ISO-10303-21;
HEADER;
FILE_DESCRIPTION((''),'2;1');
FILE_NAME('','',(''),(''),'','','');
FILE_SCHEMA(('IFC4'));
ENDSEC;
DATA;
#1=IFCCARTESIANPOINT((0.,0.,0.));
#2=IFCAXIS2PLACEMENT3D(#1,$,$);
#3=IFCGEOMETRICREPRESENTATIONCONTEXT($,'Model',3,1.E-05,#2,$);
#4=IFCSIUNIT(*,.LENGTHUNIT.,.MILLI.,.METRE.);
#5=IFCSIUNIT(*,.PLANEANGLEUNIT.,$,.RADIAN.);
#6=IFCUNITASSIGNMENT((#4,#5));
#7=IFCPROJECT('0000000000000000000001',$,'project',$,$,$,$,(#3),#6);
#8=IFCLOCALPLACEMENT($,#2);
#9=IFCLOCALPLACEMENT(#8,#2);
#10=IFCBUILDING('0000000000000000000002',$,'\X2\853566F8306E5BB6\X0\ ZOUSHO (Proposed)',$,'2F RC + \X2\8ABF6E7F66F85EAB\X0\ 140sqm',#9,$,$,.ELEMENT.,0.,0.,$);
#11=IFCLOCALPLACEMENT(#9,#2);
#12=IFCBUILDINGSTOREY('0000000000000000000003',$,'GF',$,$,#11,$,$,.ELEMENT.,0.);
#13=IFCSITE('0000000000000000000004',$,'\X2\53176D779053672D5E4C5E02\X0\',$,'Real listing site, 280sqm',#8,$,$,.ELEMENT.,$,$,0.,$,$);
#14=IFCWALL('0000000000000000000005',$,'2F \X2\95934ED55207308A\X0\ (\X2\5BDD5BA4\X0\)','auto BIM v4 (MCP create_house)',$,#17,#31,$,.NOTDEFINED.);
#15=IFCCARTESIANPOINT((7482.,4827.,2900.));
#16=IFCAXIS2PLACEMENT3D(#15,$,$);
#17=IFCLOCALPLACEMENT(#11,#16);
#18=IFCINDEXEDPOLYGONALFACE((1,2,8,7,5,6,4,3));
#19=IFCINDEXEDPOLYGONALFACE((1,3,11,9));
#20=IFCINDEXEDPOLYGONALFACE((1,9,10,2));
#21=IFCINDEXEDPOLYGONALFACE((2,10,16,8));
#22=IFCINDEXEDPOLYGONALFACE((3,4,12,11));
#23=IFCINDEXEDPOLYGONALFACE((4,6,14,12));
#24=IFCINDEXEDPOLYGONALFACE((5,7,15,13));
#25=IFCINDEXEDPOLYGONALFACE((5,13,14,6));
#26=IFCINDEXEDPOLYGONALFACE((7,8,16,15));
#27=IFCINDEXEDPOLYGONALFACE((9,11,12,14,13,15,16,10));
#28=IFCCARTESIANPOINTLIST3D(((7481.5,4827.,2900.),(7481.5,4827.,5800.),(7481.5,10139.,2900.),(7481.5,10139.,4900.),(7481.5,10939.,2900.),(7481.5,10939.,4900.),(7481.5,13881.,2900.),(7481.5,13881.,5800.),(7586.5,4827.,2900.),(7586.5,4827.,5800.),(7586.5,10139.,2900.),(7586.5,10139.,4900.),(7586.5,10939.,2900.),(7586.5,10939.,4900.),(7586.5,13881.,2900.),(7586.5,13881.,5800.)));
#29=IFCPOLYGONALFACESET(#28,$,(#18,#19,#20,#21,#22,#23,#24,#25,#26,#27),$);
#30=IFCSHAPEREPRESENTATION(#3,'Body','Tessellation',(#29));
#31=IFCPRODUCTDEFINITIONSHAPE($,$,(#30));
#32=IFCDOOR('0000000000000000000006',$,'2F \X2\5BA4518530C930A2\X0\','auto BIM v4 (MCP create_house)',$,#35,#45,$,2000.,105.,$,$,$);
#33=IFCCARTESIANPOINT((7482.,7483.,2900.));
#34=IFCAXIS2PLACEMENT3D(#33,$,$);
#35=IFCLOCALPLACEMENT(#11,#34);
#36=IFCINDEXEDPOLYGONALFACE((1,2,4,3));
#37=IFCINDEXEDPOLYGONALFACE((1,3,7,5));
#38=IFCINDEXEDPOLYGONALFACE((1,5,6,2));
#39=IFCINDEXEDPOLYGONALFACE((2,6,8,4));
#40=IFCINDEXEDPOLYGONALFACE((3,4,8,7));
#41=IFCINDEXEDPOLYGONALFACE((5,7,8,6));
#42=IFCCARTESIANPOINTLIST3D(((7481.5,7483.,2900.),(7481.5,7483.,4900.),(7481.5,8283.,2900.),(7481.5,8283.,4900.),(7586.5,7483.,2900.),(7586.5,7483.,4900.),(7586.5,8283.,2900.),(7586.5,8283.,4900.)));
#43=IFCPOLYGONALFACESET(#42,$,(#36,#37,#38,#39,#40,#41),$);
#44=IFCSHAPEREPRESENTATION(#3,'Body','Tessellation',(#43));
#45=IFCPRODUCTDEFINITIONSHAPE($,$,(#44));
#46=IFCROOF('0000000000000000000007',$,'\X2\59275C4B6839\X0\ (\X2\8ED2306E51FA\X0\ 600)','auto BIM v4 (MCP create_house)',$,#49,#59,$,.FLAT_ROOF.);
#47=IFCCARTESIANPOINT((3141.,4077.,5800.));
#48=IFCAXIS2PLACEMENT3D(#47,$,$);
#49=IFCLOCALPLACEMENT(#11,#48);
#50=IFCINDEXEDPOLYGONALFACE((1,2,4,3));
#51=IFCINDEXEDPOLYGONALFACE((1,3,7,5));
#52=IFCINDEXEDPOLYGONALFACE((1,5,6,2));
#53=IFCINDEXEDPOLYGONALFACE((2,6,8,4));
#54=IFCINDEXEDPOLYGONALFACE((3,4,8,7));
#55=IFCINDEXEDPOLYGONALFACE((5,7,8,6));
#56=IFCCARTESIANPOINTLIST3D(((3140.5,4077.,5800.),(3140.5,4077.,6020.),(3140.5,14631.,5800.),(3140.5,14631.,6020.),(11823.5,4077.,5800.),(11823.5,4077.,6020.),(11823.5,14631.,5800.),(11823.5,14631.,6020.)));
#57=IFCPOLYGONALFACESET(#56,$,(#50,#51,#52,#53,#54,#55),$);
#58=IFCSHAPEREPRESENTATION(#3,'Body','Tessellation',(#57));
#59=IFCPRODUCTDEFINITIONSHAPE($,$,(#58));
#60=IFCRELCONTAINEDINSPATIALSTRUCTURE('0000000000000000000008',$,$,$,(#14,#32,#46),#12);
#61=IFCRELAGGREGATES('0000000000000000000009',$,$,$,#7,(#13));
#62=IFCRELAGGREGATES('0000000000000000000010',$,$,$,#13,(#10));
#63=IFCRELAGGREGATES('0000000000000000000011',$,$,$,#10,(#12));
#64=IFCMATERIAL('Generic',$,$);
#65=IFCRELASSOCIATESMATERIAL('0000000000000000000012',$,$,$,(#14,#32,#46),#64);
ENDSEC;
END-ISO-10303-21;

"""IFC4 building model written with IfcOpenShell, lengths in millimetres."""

from ifc_helpers import new_model, si_unit, frame, frame_2d, origin, place, context, project, spatial, rectangle, extrude, material, element, fill, save


model = new_model("IFC4")

# Units and contexts
model_context = context("Model", 3, precision=1e-05, world=origin())
ifc_project = project(units=[si_unit("LENGTHUNIT", "METRE", prefix="MILLI"), si_unit("PLANEANGLEUNIT", "RADIAN")], contexts=[model_context])

# Site, building, storey
site_placement = place(None, origin())
site = spatial("IfcSite", under=ifc_project, at=site_placement, Name="北海道札幌市", ObjectType="Real listing site, 280sqm", CompositionType="ELEMENT", RefElevation=0.0)
building_placement = place(site_placement, origin())
building = spatial("IfcBuilding", under=site, at=building_placement, Name="蔵書の家 ZOUSHO (Proposed)", ObjectType="2F RC + 調湿書庫 140sqm", CompositionType="ELEMENT", ElevationOfRefHeight=0.0, ElevationOfTerrain=0.0)
storey_placement = place(building_placement, origin())
storey = spatial("IfcBuildingStorey", under=building, at=storey_placement, Name="GF", CompositionType="ELEMENT", Elevation=0.0)

# Shared definitions
ifc_material = material(Name="Generic")

# Wall, opening, door
wall_1_placement = place(storey_placement, frame((7482.0, 4827.0, 2900.0)))
wall_1 = element("IfcWall", 1, at=wall_1_placement, inside=storey, material=ifc_material, Name="2F 間仕切り (寝室)", Description="auto BIM v4 (MCP create_house)", PredefinedType="NOTDEFINED", context=model_context, shape_type="SweptSolid", body=[
    extrude(rectangle(XDim=105.0, YDim=9054.0, at=frame_2d((52.0, 4527.0))), frame((7482.0, 4827.0, 2900.0)), (0.0, 0.0, 1.0), 2900.0),
])
opening_1_placement = place(storey_placement, frame((7482.0, 7483.0, 2900.0)))
opening_1 = element("IfcOpeningElement", 2, at=opening_1_placement, cuts=wall_1, PredefinedType="NOTDEFINED", context=model_context, shape_type="SweptSolid", body=[
    extrude(rectangle(XDim=105.0, YDim=800.0, at=frame_2d((52.0, 400.0))), frame((7482.0, 7483.0, 2900.0)), (0.0, 0.0, 1.0), 2000.0),
])
door_1_placement = place(storey_placement, frame((7482.0, 7483.0, 2900.0)))
door_1 = element("IfcDoor", 3, at=door_1_placement, inside=storey, material=ifc_material, Name="2F 室内ドア", Description="auto BIM v4 (MCP create_house)", OverallHeight=2000.0, OverallWidth=105.0, context=model_context, shape_type="SweptSolid", body=[
    extrude(rectangle(XDim=105.0, YDim=800.0, at=frame_2d((52.0, 400.0))), frame((7482.0, 7483.0, 2900.0)), (0.0, 0.0, 1.0), 2000.0),
])
fill(opening_1, door_1)

# Roof
roof_placement = place(storey_placement, frame((3141.0, 4077.0, 5800.0)))
element("IfcRoof", 4, at=roof_placement, inside=storey, material=ifc_material, Name="大屋根 (軒の出 600)", Description="auto BIM v4 (MCP create_house)", PredefinedType="FLAT_ROOF", context=model_context, shape_type="SweptSolid", body=[
    extrude(rectangle(XDim=8683.0, YDim=10554.0, at=frame_2d((4341.0, 5277.0))), frame((3141.0, 4077.0, 5800.0)), (0.0, 0.0, 1.0), 220.0),
])

save(model, "model.ifc")
